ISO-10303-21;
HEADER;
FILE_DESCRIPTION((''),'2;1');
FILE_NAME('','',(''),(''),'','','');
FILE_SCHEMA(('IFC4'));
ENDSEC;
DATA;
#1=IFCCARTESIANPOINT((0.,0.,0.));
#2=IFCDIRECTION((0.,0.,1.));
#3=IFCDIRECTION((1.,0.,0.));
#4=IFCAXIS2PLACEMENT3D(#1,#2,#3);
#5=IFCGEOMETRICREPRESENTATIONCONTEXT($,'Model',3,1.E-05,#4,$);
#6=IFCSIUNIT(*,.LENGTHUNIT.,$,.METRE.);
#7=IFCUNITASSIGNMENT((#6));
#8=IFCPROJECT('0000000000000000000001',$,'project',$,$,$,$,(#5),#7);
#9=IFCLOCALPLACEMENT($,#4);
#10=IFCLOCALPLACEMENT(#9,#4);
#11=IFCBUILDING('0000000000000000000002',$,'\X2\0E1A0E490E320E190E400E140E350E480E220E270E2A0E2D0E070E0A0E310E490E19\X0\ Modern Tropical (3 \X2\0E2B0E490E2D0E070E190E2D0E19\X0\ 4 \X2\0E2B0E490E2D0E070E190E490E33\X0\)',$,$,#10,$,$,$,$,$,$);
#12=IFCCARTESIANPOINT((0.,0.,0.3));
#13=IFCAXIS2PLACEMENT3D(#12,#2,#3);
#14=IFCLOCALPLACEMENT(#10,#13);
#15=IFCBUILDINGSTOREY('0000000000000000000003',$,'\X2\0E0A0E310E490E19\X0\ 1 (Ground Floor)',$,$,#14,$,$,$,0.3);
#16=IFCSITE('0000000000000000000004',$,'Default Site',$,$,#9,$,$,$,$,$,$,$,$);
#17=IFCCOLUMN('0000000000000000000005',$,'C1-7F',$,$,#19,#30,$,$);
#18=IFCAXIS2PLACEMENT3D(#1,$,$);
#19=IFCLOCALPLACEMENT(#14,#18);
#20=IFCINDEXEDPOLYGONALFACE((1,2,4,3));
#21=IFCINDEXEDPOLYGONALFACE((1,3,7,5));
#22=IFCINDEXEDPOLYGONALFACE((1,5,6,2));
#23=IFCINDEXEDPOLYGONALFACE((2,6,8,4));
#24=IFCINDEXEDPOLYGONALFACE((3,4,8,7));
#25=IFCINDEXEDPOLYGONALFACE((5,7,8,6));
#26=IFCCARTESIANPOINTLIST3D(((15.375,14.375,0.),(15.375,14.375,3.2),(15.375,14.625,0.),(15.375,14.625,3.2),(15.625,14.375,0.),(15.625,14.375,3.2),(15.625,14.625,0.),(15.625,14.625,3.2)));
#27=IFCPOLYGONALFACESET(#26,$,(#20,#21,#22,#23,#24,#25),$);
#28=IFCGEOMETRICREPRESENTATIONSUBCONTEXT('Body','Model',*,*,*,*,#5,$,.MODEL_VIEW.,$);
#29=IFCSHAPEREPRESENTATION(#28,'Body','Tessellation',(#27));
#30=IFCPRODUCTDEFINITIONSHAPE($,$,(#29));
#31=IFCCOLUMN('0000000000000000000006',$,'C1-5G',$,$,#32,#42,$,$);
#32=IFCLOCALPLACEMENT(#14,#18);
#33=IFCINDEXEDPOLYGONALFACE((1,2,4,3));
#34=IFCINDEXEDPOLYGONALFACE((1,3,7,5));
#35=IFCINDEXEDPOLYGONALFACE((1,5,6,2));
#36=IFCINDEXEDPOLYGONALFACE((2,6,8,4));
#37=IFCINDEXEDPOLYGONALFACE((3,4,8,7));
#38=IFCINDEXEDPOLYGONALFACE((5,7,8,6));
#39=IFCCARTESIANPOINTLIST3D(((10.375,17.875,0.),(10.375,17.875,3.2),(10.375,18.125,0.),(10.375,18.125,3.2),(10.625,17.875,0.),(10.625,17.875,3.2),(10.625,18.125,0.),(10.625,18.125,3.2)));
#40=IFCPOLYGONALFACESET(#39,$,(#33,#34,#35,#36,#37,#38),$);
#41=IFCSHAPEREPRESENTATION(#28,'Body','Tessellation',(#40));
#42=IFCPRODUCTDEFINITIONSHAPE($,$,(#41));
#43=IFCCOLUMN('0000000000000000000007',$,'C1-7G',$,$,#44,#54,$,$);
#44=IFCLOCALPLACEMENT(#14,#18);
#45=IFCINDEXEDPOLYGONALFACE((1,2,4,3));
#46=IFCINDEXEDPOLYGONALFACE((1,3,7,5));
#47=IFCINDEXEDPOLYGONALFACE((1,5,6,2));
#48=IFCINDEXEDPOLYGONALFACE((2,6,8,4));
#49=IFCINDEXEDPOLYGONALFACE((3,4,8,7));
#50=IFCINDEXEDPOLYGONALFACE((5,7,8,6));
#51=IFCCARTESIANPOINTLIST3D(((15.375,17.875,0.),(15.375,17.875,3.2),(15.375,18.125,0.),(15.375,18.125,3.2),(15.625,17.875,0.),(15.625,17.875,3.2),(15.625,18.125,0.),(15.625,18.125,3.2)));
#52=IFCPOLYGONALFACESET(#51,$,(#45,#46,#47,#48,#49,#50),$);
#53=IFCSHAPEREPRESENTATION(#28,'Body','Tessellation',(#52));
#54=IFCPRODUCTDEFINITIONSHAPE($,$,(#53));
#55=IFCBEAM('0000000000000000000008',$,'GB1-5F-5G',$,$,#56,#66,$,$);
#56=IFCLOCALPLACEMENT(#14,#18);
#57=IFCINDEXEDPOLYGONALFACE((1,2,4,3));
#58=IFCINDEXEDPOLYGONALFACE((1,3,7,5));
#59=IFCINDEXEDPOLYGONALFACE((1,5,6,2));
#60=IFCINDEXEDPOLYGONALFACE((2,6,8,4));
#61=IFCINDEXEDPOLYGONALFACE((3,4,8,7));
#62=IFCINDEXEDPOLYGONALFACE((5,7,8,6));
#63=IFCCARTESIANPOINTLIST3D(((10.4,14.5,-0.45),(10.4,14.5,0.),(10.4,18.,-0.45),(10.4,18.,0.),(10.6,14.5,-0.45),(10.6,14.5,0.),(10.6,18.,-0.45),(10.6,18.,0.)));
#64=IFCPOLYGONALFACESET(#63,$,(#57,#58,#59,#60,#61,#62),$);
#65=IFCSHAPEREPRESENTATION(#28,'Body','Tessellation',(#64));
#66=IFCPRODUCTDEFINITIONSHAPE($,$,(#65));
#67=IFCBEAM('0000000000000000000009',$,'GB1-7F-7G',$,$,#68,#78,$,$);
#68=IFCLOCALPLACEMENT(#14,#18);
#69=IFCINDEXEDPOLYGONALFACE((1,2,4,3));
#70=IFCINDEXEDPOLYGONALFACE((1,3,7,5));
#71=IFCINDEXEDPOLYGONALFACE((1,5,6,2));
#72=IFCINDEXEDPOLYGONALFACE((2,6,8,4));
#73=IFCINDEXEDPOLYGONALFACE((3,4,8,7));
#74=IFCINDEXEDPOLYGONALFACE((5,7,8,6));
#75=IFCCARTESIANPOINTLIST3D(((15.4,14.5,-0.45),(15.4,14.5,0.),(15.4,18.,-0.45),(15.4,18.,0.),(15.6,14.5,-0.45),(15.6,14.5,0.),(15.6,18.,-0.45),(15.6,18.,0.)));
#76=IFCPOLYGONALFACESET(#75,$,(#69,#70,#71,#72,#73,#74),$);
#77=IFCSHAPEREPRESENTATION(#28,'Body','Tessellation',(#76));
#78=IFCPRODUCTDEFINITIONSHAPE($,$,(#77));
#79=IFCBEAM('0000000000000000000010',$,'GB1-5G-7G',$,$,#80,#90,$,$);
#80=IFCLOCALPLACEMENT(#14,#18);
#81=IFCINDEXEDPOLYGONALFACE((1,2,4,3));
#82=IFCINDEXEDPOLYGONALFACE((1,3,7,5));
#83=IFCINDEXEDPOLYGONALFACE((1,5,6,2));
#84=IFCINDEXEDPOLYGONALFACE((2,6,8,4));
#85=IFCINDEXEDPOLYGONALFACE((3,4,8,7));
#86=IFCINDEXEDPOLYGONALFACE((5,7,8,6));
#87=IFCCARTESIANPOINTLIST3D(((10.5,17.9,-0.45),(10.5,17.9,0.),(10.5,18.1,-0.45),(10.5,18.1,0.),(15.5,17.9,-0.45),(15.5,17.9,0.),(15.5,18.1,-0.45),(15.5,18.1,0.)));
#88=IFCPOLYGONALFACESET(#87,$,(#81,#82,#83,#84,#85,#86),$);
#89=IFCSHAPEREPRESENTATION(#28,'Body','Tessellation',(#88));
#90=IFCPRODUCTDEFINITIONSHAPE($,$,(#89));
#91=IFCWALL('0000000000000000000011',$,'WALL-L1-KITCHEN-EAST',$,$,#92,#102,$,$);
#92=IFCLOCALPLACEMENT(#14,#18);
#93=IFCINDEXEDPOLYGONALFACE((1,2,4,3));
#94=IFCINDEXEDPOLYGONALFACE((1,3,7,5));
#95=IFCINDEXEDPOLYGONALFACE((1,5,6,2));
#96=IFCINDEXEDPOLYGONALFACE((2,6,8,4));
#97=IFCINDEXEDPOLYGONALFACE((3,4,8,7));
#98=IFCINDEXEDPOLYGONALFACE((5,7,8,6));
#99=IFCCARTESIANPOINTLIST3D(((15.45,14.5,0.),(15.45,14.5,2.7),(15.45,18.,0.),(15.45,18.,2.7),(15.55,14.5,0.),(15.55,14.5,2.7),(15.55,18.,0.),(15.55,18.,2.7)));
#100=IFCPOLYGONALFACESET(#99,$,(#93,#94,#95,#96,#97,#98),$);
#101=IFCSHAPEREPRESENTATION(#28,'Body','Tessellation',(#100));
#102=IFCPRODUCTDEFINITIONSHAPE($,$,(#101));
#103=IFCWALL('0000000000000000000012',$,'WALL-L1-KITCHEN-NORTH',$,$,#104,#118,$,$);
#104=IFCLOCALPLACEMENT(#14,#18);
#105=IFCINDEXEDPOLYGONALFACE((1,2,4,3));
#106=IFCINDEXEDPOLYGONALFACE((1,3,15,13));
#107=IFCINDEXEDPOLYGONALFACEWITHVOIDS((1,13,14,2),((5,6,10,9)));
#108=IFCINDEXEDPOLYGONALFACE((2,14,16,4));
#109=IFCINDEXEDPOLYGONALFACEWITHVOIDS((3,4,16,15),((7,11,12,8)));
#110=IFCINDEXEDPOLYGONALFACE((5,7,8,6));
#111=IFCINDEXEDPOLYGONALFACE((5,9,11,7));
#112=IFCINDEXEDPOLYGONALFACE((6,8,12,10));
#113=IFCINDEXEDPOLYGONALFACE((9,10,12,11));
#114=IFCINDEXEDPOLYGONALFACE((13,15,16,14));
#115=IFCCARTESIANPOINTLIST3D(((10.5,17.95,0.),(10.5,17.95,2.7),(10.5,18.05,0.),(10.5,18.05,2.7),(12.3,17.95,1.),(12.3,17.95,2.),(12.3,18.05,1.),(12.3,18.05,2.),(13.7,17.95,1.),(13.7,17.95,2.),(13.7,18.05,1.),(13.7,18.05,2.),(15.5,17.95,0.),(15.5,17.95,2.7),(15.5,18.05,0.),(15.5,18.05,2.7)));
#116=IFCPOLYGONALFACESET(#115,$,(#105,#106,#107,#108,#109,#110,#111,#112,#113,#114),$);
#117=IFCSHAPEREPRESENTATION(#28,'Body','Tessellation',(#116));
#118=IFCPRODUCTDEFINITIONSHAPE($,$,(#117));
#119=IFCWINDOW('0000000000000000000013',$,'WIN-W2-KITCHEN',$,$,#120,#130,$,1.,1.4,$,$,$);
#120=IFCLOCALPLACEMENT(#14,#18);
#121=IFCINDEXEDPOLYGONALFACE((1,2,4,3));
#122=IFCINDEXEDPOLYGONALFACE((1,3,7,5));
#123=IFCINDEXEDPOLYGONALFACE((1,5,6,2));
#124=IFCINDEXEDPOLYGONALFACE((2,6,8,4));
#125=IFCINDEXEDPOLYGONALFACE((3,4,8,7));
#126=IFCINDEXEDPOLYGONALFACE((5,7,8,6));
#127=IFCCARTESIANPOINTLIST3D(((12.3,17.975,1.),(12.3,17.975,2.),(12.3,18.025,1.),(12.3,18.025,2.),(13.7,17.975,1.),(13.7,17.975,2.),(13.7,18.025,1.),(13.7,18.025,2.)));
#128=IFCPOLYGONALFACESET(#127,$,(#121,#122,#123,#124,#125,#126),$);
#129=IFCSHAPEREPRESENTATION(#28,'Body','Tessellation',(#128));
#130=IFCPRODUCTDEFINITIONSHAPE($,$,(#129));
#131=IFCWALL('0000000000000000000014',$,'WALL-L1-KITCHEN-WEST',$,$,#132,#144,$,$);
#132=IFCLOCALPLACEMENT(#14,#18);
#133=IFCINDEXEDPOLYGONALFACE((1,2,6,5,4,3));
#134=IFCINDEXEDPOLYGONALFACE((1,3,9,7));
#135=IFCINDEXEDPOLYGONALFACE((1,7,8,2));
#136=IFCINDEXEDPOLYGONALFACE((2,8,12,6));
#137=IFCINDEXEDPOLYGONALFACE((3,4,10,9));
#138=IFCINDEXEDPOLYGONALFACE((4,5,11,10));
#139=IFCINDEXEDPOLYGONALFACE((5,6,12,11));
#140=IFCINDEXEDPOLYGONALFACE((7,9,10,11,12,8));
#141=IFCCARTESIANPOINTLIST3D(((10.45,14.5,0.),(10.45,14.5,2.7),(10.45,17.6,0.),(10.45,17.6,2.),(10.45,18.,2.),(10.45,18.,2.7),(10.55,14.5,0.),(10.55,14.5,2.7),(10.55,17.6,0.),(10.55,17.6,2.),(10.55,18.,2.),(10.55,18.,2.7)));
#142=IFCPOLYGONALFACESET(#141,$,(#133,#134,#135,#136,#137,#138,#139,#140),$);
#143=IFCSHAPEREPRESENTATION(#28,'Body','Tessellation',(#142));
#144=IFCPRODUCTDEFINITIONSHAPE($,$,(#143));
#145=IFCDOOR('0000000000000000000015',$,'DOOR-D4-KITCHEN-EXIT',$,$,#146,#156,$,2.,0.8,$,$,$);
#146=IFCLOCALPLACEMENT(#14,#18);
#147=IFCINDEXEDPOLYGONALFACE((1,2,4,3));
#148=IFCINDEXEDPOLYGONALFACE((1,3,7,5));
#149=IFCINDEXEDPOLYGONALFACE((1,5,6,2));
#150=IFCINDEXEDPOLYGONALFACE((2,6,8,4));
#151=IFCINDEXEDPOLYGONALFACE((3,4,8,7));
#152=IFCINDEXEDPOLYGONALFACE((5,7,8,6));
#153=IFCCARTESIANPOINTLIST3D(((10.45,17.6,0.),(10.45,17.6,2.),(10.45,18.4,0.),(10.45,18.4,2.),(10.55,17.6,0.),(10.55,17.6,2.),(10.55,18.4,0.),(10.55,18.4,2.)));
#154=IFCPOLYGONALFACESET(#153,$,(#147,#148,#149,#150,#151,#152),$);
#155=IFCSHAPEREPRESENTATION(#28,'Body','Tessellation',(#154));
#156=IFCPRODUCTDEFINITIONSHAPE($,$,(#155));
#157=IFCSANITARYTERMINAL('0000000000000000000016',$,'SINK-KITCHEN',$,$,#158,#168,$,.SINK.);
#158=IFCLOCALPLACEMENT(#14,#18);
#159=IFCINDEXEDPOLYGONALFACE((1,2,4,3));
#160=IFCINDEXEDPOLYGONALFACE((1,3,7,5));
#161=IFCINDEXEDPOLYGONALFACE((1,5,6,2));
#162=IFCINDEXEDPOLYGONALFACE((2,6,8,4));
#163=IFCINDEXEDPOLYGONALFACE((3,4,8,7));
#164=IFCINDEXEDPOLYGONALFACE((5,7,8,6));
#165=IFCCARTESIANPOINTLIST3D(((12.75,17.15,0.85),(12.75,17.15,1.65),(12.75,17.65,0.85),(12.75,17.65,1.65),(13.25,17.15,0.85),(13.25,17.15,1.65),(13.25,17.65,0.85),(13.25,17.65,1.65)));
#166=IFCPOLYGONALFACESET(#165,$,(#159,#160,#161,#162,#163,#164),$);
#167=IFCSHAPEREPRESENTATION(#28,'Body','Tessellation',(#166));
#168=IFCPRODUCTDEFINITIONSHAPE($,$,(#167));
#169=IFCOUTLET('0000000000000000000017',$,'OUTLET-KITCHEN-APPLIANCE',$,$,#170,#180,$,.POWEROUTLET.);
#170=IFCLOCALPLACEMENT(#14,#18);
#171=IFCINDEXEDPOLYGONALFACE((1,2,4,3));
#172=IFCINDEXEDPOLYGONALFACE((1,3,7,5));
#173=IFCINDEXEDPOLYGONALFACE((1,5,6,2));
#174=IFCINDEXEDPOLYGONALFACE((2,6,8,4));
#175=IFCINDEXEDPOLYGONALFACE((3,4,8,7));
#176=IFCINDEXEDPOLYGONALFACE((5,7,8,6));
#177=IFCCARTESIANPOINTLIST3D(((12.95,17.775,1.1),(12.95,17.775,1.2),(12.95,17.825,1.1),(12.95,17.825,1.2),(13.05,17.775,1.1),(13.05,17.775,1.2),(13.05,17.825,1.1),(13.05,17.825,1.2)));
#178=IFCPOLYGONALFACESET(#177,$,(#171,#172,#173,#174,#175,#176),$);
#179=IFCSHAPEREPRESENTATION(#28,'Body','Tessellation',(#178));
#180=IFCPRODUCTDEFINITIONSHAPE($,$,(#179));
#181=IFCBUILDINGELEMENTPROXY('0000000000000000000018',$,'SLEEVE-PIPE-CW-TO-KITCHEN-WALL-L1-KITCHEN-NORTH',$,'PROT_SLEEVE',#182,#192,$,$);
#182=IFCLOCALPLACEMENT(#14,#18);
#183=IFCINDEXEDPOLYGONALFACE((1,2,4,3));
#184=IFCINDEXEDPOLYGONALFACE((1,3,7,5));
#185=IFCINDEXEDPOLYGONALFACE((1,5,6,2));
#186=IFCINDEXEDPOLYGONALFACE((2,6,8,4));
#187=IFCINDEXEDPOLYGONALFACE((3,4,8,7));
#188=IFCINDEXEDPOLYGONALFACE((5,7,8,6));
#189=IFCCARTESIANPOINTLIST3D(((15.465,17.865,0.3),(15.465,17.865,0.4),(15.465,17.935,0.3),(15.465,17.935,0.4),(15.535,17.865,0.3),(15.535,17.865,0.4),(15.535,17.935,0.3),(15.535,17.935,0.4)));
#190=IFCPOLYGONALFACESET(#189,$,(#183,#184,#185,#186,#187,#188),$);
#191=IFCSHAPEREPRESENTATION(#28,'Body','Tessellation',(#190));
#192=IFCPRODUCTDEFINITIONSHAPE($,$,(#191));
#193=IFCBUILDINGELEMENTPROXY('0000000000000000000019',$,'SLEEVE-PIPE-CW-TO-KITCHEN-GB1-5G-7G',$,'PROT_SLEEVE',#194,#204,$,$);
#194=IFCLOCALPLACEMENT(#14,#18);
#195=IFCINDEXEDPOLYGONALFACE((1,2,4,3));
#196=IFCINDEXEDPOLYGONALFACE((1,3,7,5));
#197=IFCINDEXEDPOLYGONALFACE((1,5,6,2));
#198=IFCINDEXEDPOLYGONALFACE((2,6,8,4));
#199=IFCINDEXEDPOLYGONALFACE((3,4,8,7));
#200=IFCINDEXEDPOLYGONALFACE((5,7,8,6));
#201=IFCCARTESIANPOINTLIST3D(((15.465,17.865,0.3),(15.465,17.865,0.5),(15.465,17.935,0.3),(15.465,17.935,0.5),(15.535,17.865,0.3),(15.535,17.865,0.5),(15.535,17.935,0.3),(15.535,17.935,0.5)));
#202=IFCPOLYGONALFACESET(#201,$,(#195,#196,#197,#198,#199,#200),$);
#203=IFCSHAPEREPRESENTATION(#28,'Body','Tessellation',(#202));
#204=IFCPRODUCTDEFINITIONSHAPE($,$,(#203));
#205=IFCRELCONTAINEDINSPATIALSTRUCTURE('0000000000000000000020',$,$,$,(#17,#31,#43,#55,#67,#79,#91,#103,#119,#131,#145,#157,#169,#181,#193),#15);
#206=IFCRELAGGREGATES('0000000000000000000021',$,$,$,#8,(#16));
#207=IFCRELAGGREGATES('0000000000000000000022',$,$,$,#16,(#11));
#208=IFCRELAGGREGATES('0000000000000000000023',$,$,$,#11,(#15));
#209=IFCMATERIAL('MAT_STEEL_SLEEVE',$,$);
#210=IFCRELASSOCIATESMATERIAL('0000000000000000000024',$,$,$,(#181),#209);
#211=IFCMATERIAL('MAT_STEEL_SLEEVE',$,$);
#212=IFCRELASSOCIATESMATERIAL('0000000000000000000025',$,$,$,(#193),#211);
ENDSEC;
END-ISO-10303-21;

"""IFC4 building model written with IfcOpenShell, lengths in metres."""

from ifc_helpers import new_model, si_unit, frame, origin_with_axes, origin_2d, place, context, subcontext, project, spatial, rectangle, extrude, material, element, fill, save


model = new_model("IFC4")

# Units and contexts
model_context = context("Model", 3, precision=1e-05, world=origin_with_axes())
body_context = subcontext(model_context, "Body", "Model", "MODEL_VIEW")
ifc_project = project(units=[si_unit("LENGTHUNIT", "METRE")], contexts=[model_context])

# Site, building, storey
site_placement = place(None, origin_with_axes())
site = spatial("IfcSite", under=ifc_project, at=site_placement, Name="Default Site")
building_placement = place(site_placement, origin_with_axes())
building = spatial("IfcBuilding", under=site, at=building_placement, Name="บ้านเดี่ยวสองชั้น Modern Tropical (3 ห้องนอน 4 ห้องน้ำ)")
storey_placement = place(building_placement, frame((0.0, 0.0, 0.3), z_axis=(0.0, 0.0, 1.0), x_axis=(1.0, 0.0, 0.0)))
storey = spatial("IfcBuildingStorey", under=building, at=storey_placement, Name="ชั้น 1 (Ground Floor)", Elevation=0.3)

# Columns
for number, where, z_axis, x_axis, name in (
    (1, (15.5, 14.5, 0.0), (0.0, 0.0, 1.0), (1.0, 0.0, 0.0), "C1-7F"),
    (2, (10.5, 18.0, 0.0), (0.0, 0.0, 1.0), (1.0, 0.0, 0.0), "C1-5G"),
    (3, (15.5, 18.0, 0.0), (0.0, 0.0, 1.0), (1.0, 0.0, 0.0), "C1-7G"),
):
    element("IfcColumn", number, at=place(storey_placement, frame(where, z_axis=z_axis, x_axis=x_axis)), inside=storey, Name=name, context=body_context, shape_type="SweptSolid", body=[
        extrude(rectangle(XDim=0.25, YDim=0.25, at=origin_2d()), origin_with_axes(), (0.0, 0.0, 1.0), 3.2),
    ])

# Beams
for number, where, z_axis, x_axis, name in (
    (4, (10.5, 14.5, -0.225), (0.0, 1.0, 0.0), (-1.0, 0.0, 0.0), "GB1-5F-5G"),
    (5, (15.5, 14.5, -0.225), (0.0, 1.0, 0.0), (-1.0, 0.0, 0.0), "GB1-7F-7G"),
):
    element("IfcBeam", number, at=place(storey_placement, frame(where, z_axis=z_axis, x_axis=x_axis)), inside=storey, Name=name, context=body_context, shape_type="SweptSolid", body=[
        extrude(rectangle(XDim=0.2, YDim=0.45, at=origin_2d()), origin_with_axes(), (0.0, 0.0, 1.0), 3.5),
    ])
beam_placement = place(storey_placement, frame((10.5, 18.0, -0.225), z_axis=(1.0, 0.0, 0.0), x_axis=(0.0, 1.0, 0.0)))
element("IfcBeam", 6, at=beam_placement, inside=storey, Name="GB1-5G-7G", context=body_context, shape_type="SweptSolid", body=[
    extrude(rectangle(XDim=0.2, YDim=0.45, at=origin_2d()), origin_with_axes(), (0.0, 0.0, 1.0), 5.0),
])

# Wall
wall_1_placement = place(storey_placement, frame((15.5, 16.25, 0.0), z_axis=(0.0, 0.0, 1.0), x_axis=(0.0, 1.0, 0.0)))
element("IfcWall", 7, at=wall_1_placement, inside=storey, Name="WALL-L1-KITCHEN-EAST", context=body_context, shape_type="SweptSolid", body=[
    extrude(rectangle(XDim=3.5, YDim=0.1, at=origin_2d()), origin_with_axes(), (0.0, 0.0, 1.0), 2.7),
])

# Wall, opening, window
wall_2_placement = place(storey_placement, frame((13.0, 18.0, 0.0), z_axis=(0.0, 0.0, 1.0), x_axis=(1.0, 0.0, 0.0)))
wall_2 = element("IfcWall", 8, at=wall_2_placement, inside=storey, Name="WALL-L1-KITCHEN-NORTH", context=body_context, shape_type="SweptSolid", body=[
    extrude(rectangle(XDim=5.0, YDim=0.1, at=origin_2d()), origin_with_axes(), (0.0, 0.0, 1.0), 2.7),
])
opening_1_placement = place(wall_2_placement, frame((0.0, 0.0, 1.0), z_axis=(0.0, 0.0, 1.0), x_axis=(1.0, 0.0, 0.0)))
opening_1 = element("IfcOpeningElement", 9, at=opening_1_placement, cuts=wall_2, context=body_context, shape_type="SweptSolid", body=[
    extrude(rectangle(XDim=1.4, YDim=0.12, at=origin_2d()), origin_with_axes(), (0.0, 0.0, 1.0), 1.0),
])
window_placement = place(opening_1_placement, origin_with_axes())
window = element("IfcWindow", 10, at=window_placement, inside=storey, Name="WIN-W2-KITCHEN", OverallHeight=1.0, OverallWidth=1.4, context=body_context, shape_type="SweptSolid", body=[
    extrude(rectangle(XDim=1.4, YDim=0.05, at=origin_2d()), origin_with_axes(), (0.0, 0.0, 1.0), 1.0),
])
fill(opening_1, window)

# Wall, opening, door
wall_3_placement = place(storey_placement, frame((10.5, 16.25, 0.0), z_axis=(0.0, 0.0, 1.0), x_axis=(0.0, 1.0, 0.0)))
wall_3 = element("IfcWall", 11, at=wall_3_placement, inside=storey, Name="WALL-L1-KITCHEN-WEST", context=body_context, shape_type="SweptSolid", body=[
    extrude(rectangle(XDim=3.5, YDim=0.1, at=origin_2d()), origin_with_axes(), (0.0, 0.0, 1.0), 2.7),
])
opening_2_placement = place(wall_3_placement, frame((1.75, 0.0, 0.0), z_axis=(0.0, 0.0, 1.0), x_axis=(1.0, 0.0, 0.0)))
opening_2 = element("IfcOpeningElement", 12, at=opening_2_placement, cuts=wall_3, context=body_context, shape_type="SweptSolid", body=[
    extrude(rectangle(XDim=0.8, YDim=0.12, at=origin_2d()), origin_with_axes(), (0.0, 0.0, 1.0), 2.0),
])
door_placement = place(opening_2_placement, origin_with_axes())
door = element("IfcDoor", 13, at=door_placement, inside=storey, Name="DOOR-D4-KITCHEN-EXIT", OverallHeight=2.0, OverallWidth=0.8, context=body_context, shape_type="SweptSolid", body=[
    extrude(rectangle(XDim=0.8, YDim=0.1, at=origin_2d()), origin_with_axes(), (0.0, 0.0, 1.0), 2.0),
])
fill(opening_2, door)

# Sanitary terminal
sanitary_terminal_placement = place(storey_placement, frame((13.0, 17.4, 0.85), z_axis=(0.0, 0.0, 1.0), x_axis=(1.0, 0.0, 0.0)))
element("IfcSanitaryTerminal", 14, at=sanitary_terminal_placement, inside=storey, Name="SINK-KITCHEN", PredefinedType="SINK", context=body_context, shape_type="SweptSolid", body=[
    extrude(rectangle(XDim=0.5, YDim=0.5, at=origin_2d()), origin_with_axes(), (0.0, 0.0, 1.0), 0.8),
])

# Outlet
outlet_placement = place(storey_placement, frame((13.0, 17.8, 1.1), z_axis=(0.0, 0.0, 1.0), x_axis=(1.0, 0.0, 0.0)))
element("IfcOutlet", 15, at=outlet_placement, inside=storey, Name="OUTLET-KITCHEN-APPLIANCE", PredefinedType="POWEROUTLET", context=body_context, shape_type="SweptSolid", body=[
    extrude(rectangle(XDim=0.1, YDim=0.05, at=origin_2d()), origin_with_axes(), (0.0, 0.0, 1.0), 0.1),
])

# Building element proxies
ifc_material_1 = material(Name="MAT_STEEL_SLEEVE")
proxy_1_placement = place(storey_placement, frame((15.5, 17.9, 0.3), z_axis=(0.0, 0.0, 1.0), x_axis=(1.0, 0.0, 0.0)))
element("IfcBuildingElementProxy", 16, at=proxy_1_placement, inside=storey, material=ifc_material_1, Name="SLEEVE-PIPE-CW-TO-KITCHEN-WALL-L1-KITCHEN-NORTH", ObjectType="PROT_SLEEVE", context=body_context, shape_type="SweptSolid", body=[
    extrude(rectangle(XDim=0.07, YDim=0.07, at=origin_2d()), origin_with_axes(), (0.0, 0.0, 1.0), 0.1),
])
ifc_material_2 = material(Name="MAT_STEEL_SLEEVE")
proxy_2_placement = place(storey_placement, frame((15.5, 17.9, 0.3), z_axis=(0.0, 0.0, 1.0), x_axis=(1.0, 0.0, 0.0)))
element("IfcBuildingElementProxy", 17, at=proxy_2_placement, inside=storey, material=ifc_material_2, Name="SLEEVE-PIPE-CW-TO-KITCHEN-GB1-5G-7G", ObjectType="PROT_SLEEVE", context=body_context, shape_type="SweptSolid", body=[
    extrude(rectangle(XDim=0.07, YDim=0.07, at=origin_2d()), origin_with_axes(), (0.0, 0.0, 1.0), 0.2),
])

save(model, "model.ifc")
